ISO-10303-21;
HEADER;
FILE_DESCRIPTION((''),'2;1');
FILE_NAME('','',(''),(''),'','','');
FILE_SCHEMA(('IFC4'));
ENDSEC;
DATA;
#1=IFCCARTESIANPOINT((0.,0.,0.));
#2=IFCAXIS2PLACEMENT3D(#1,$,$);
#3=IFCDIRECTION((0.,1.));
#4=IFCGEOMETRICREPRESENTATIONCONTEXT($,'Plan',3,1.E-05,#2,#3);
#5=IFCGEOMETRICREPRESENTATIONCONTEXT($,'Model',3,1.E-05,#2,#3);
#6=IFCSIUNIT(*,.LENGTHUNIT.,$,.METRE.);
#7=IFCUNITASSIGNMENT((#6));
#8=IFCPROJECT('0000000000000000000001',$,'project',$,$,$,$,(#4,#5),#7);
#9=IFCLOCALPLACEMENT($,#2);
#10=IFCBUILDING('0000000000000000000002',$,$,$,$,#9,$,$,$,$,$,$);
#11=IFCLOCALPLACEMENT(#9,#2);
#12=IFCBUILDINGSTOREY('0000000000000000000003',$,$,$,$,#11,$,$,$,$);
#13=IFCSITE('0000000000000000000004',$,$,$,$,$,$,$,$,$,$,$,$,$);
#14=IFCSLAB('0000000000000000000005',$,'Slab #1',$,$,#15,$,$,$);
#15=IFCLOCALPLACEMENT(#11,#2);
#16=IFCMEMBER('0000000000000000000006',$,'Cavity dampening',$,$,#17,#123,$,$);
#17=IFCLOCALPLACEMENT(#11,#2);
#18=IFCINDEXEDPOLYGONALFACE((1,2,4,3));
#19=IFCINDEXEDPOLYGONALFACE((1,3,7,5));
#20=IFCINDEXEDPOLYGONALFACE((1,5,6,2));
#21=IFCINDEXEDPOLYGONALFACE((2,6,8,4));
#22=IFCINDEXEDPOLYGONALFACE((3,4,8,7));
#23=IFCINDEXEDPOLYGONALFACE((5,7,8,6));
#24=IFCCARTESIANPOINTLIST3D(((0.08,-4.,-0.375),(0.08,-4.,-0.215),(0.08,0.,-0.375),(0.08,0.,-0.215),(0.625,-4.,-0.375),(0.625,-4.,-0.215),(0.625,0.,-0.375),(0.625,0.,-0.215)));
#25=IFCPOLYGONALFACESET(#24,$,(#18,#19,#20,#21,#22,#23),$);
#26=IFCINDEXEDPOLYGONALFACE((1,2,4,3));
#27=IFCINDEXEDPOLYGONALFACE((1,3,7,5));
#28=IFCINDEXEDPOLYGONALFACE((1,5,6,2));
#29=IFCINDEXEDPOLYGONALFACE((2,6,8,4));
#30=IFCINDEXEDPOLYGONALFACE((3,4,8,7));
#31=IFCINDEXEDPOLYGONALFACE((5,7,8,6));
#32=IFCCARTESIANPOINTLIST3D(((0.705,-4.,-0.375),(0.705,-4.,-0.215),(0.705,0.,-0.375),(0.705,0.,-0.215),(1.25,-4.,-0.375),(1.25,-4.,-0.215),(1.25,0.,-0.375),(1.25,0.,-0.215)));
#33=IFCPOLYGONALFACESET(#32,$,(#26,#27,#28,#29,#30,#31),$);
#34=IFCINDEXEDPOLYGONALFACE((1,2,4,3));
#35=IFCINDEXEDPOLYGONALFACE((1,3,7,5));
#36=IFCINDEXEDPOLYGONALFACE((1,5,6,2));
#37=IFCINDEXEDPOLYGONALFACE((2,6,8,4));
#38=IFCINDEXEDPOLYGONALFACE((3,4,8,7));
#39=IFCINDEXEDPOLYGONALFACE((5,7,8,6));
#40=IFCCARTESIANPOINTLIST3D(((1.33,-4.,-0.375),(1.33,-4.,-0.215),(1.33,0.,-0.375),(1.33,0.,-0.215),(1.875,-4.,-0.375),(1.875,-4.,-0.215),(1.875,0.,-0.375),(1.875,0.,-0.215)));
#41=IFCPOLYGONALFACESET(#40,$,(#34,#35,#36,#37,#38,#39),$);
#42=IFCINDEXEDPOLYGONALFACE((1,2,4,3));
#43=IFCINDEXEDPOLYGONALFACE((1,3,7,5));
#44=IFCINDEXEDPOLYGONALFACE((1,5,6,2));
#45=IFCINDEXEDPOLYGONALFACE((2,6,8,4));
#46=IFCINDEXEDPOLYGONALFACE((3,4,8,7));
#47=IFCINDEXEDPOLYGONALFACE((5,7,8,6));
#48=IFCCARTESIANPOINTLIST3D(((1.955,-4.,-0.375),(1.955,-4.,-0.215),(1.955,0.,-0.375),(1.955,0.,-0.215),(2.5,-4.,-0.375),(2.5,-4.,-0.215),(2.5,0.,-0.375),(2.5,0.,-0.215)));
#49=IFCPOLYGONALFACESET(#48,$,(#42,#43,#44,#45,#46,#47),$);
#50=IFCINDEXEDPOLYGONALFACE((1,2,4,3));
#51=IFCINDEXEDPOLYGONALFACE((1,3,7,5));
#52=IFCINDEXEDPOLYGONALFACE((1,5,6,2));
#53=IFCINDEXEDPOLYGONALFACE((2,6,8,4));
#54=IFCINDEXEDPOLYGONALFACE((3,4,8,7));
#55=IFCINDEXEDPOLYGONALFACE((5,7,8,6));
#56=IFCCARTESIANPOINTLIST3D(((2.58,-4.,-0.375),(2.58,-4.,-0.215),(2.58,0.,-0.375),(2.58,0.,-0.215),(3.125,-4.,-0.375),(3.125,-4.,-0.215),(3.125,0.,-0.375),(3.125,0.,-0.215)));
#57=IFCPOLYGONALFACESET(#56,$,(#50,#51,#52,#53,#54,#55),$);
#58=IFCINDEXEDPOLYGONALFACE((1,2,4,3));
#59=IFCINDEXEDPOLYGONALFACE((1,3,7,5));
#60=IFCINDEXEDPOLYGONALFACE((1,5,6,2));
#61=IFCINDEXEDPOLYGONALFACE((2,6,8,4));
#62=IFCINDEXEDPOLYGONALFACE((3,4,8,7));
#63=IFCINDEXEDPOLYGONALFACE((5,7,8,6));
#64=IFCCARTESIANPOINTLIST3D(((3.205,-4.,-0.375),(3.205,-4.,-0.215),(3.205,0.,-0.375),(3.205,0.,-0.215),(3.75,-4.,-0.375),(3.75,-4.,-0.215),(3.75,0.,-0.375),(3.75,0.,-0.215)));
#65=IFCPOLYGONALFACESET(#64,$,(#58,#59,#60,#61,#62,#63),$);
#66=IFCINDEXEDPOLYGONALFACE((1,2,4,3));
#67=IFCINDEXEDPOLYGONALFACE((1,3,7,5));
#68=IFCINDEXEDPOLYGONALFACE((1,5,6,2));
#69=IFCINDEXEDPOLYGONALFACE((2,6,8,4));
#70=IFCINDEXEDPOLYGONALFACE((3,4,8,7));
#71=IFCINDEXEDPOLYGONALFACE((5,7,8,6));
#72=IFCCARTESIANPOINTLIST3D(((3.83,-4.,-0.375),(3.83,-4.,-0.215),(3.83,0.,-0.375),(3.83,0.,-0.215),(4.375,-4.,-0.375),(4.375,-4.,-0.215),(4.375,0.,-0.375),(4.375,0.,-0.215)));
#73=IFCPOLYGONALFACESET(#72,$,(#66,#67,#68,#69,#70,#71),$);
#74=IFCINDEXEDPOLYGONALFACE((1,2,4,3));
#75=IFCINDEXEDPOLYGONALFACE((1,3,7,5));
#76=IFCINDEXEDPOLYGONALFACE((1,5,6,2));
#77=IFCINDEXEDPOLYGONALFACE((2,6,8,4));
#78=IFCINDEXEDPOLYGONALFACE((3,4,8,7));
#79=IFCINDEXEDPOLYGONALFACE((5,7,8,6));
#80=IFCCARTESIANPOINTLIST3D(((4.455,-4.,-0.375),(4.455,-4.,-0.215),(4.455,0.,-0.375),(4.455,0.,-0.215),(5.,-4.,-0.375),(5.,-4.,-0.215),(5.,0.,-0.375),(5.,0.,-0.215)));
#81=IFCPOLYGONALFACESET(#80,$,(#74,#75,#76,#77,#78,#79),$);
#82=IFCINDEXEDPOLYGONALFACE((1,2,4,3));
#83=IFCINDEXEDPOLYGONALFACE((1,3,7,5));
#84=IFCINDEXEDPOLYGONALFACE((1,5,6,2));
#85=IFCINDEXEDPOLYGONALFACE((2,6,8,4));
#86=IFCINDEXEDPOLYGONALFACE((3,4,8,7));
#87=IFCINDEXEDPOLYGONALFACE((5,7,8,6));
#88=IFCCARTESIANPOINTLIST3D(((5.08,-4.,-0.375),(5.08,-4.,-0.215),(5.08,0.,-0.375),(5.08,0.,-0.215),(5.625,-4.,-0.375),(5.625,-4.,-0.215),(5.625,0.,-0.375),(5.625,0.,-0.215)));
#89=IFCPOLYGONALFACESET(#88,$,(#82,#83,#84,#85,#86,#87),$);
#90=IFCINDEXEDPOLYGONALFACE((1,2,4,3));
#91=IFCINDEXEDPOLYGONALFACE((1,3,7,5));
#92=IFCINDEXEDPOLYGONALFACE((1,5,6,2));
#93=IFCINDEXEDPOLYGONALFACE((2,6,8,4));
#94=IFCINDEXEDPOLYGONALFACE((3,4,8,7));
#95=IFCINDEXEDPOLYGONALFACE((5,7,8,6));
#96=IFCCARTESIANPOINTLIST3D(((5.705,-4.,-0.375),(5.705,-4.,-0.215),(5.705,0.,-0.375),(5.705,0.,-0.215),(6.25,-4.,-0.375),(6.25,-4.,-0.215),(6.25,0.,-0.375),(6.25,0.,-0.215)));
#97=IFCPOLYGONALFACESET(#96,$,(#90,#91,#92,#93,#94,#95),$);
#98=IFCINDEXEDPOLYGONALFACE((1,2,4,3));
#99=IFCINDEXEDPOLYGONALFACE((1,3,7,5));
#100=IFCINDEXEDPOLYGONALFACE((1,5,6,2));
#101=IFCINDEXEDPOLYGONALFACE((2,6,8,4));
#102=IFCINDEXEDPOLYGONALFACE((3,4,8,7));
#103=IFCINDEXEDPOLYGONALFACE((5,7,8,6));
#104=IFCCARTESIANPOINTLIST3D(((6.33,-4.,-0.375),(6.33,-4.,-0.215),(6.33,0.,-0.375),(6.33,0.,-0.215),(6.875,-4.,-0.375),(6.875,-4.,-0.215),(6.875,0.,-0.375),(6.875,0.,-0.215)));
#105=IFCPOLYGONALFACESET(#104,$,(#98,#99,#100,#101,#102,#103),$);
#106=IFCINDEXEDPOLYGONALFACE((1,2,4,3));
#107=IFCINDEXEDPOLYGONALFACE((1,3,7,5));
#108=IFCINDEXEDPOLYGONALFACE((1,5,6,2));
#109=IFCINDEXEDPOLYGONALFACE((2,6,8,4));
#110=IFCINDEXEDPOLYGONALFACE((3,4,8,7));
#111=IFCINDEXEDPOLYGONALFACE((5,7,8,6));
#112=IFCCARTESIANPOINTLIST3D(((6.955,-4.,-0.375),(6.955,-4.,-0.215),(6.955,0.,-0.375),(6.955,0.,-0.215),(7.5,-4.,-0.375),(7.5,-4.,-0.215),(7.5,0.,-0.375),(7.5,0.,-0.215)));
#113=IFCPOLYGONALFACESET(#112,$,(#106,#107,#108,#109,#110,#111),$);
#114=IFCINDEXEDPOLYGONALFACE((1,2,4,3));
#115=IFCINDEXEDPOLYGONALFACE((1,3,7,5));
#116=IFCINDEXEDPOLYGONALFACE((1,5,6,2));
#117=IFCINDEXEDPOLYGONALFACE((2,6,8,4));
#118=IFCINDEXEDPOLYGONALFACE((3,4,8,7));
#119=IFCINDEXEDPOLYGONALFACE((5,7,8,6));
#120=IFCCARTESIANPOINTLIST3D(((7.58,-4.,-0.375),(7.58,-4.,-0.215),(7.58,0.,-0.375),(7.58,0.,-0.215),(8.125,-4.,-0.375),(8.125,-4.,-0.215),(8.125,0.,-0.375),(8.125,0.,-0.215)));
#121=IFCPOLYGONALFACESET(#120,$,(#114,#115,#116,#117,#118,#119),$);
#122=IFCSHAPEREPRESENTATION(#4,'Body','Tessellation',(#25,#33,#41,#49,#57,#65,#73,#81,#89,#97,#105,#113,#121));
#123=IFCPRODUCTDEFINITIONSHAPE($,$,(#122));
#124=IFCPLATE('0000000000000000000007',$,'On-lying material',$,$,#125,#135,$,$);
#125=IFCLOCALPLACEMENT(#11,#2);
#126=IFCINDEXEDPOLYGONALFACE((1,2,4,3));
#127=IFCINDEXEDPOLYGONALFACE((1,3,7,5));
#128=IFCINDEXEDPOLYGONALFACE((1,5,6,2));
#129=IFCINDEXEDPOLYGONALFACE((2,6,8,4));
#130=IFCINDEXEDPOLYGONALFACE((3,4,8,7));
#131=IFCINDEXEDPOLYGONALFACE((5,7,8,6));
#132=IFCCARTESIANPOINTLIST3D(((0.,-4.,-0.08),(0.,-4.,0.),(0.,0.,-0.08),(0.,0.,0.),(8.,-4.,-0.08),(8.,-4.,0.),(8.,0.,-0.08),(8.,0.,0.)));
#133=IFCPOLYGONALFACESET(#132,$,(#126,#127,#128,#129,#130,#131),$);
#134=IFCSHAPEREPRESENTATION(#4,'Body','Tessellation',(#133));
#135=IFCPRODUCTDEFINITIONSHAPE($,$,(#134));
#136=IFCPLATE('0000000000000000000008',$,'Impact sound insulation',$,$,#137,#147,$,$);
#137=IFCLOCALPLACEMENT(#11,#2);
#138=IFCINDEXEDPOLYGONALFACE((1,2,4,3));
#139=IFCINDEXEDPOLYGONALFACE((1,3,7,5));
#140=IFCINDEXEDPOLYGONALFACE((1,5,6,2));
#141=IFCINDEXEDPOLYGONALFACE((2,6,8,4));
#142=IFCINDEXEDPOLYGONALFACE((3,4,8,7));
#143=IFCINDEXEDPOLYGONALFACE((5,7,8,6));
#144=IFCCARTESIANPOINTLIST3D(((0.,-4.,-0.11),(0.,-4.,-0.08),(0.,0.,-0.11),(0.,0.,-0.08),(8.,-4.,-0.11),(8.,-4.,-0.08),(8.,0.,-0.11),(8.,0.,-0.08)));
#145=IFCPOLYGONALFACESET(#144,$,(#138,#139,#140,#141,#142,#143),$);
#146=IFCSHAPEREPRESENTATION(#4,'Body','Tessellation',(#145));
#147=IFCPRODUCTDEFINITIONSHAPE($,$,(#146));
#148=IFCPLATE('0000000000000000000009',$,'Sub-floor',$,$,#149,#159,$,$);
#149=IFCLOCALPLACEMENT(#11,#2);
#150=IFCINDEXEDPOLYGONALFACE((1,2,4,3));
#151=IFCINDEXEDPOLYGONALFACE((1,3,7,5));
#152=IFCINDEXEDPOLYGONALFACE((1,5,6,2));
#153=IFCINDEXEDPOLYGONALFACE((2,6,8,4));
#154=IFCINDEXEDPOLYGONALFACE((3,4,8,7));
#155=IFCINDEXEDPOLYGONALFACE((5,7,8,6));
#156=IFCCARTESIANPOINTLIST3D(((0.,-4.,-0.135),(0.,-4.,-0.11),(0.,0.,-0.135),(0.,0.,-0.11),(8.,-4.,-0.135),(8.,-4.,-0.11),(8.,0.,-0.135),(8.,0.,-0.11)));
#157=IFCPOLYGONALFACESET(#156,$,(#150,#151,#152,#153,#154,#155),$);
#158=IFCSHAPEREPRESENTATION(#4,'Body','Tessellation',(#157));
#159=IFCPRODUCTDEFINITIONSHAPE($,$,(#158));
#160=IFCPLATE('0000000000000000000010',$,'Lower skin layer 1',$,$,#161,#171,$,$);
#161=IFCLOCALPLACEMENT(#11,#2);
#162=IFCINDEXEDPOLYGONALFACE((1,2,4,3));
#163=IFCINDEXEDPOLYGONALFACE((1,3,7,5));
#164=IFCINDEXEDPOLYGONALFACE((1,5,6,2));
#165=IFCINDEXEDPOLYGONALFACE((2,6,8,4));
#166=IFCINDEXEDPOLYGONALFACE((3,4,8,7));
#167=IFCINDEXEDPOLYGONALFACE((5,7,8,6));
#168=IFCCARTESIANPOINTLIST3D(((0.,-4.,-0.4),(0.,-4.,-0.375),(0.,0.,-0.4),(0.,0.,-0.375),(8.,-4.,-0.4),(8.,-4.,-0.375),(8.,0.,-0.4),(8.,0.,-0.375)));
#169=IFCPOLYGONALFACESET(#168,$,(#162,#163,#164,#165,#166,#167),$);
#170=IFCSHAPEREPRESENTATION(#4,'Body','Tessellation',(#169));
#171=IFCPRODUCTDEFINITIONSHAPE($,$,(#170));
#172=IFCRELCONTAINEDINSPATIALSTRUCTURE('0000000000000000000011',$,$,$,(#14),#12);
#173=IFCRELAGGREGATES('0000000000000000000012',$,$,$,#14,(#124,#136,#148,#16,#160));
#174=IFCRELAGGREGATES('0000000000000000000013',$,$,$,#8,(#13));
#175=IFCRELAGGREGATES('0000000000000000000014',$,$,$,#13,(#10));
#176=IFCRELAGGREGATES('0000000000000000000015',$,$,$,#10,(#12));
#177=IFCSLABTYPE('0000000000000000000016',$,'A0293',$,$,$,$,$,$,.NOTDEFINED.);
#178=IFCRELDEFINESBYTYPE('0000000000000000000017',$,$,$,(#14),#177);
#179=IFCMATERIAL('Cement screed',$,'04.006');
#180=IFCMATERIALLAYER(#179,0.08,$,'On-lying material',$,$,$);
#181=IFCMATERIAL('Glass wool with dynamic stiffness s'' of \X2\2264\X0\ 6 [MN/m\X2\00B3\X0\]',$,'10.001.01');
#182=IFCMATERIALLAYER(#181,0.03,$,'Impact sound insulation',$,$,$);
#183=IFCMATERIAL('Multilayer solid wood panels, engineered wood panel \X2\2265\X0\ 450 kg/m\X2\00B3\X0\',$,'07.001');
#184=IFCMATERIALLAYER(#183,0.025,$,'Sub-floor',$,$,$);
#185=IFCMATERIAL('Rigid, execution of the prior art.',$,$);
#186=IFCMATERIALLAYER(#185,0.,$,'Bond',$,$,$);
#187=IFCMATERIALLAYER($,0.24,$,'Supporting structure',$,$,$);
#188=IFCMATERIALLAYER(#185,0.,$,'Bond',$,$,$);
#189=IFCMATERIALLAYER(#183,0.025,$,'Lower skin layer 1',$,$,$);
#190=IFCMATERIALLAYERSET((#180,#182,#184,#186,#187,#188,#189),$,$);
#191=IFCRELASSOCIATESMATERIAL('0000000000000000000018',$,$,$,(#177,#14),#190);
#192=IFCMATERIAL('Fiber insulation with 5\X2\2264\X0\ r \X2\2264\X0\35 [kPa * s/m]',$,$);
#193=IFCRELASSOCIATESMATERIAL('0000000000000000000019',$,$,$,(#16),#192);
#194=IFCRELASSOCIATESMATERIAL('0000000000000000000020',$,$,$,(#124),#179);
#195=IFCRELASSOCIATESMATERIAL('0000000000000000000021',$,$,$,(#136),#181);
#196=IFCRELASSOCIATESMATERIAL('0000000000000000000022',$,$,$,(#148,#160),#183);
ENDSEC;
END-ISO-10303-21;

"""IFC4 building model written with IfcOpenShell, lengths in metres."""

from ifc_helpers import new_model, si_unit, direction, frame, frame_2d, origin, origin_with_axes, place, context, project, spatial, rectangle, extrude, material, layer, layer_set, type_object, element, aggregate, save


model = new_model("IFC4")

# Units and contexts
plan_context = context("Plan", 3, precision=1e-05, world=origin(), true_north=direction((0.0, 1.0)))
model_context = context("Model", 3, precision=1e-05, world=origin(), true_north=direction((0.0, 1.0)))
ifc_project = project(units=[si_unit("LENGTHUNIT", "METRE")], contexts=[plan_context, model_context])

# Site, building, storey
site = spatial("IfcSite", under=ifc_project)
building_placement = place(None, origin())
building = spatial("IfcBuilding", under=site, at=building_placement)
storey_placement = place(building_placement, origin())
storey = spatial("IfcBuildingStorey", under=building, at=storey_placement)

# Slab, member, plates
ifc_material_1 = material(Name="Cement screed", Category="04.006")
ifc_layer_1 = layer(ifc_material_1, 0.08, Name="On-lying material")
ifc_material_2 = material(Name="Glass wool with dynamic stiffness s' of ≤ 6 [MN/m³]", Category="10.001.01")
ifc_layer_2 = layer(ifc_material_2, 0.03, Name="Impact sound insulation")
ifc_material_3 = material(Name="Multilayer solid wood panels, engineered wood panel ≥ 450 kg/m³", Category="07.001")
ifc_layer_3 = layer(ifc_material_3, 0.025, Name="Sub-floor")
ifc_material_4 = material(Name="Rigid, execution of the prior art.")
ifc_layer_4 = layer(ifc_material_4, 0.0, Name="Bond")
ifc_layer_5 = layer(None, 0.24, Name="Supporting structure")
ifc_layer_6 = layer(ifc_material_4, 0.0, Name="Bond")
ifc_layer_7 = layer(ifc_material_3, 0.025, Name="Lower skin layer 1")
ifc_layer_set = layer_set([ifc_layer_1, ifc_layer_2, ifc_layer_3, ifc_layer_4, ifc_layer_5, ifc_layer_6, ifc_layer_7])
slab_type = type_object("IfcSlabType", Name="A0293", PredefinedType="NOTDEFINED", material=ifc_layer_set)
slab_placement = place(None, frame((0.0, 0.0, 0.0), z_axis=(0.0, 0.0, -1.0), x_axis=(1.0, 0.0, 0.0)))
slab = element("IfcSlab", 1, at=slab_placement, inside=storey, type_object=slab_type, material=ifc_layer_set, Name="Slab #1")
ifc_material_5 = material(Name="Fiber insulation with 5≤ r ≤35 [kPa * s/m]")
member_1_placement = place(slab_placement, origin())
member_1 = element("IfcMember", 2, at=member_1_placement, material=ifc_material_5, Name="Cavity dampening", context=plan_context, shape_type="SweptSolid", body=[
    extrude(rectangle(XDim=0.545, YDim=0.16, at=frame_2d((0.2725, 0.08), x_axis=(1.0, 0.0))), frame((0.08, 4.0, 0.215), z_axis=(0.0, -1.0, 0.0), x_axis=(1.0, 0.0, 0.0)), (0.0, 0.0, 1.0), 4.0),
    extrude(rectangle(XDim=0.545, YDim=0.16, at=frame_2d((0.2725, 0.08), x_axis=(1.0, 0.0))), frame((0.705, 4.0, 0.215), z_axis=(0.0, -1.0, 0.0), x_axis=(1.0, 0.0, 0.0)), (0.0, 0.0, 1.0), 4.0),
    extrude(rectangle(XDim=0.545, YDim=0.16, at=frame_2d((0.2725, 0.08), x_axis=(1.0, 0.0))), frame((1.33, 4.0, 0.215), z_axis=(0.0, -1.0, 0.0), x_axis=(1.0, 0.0, 0.0)), (0.0, 0.0, 1.0), 4.0),
    extrude(rectangle(XDim=0.545, YDim=0.16, at=frame_2d((0.2725, 0.08), x_axis=(1.0, 0.0))), frame((1.955, 4.0, 0.215), z_axis=(0.0, -1.0, 0.0), x_axis=(1.0, 0.0, 0.0)), (0.0, 0.0, 1.0), 4.0),
    extrude(rectangle(XDim=0.545, YDim=0.16, at=frame_2d((0.2725, 0.08), x_axis=(1.0, 0.0))), frame((2.58, 4.0, 0.215), z_axis=(0.0, -1.0, 0.0), x_axis=(1.0, 0.0, 0.0)), (0.0, 0.0, 1.0), 4.0),
    extrude(rectangle(XDim=0.545, YDim=0.16, at=frame_2d((0.2725, 0.08), x_axis=(1.0, 0.0))), frame((3.205, 4.0, 0.215), z_axis=(0.0, -1.0, 0.0), x_axis=(1.0, 0.0, 0.0)), (0.0, 0.0, 1.0), 4.0),
    extrude(rectangle(XDim=0.545, YDim=0.16, at=frame_2d((0.2725, 0.08), x_axis=(1.0, 0.0))), frame((3.83, 4.0, 0.215), z_axis=(0.0, -1.0, 0.0), x_axis=(1.0, 0.0, 0.0)), (0.0, 0.0, 1.0), 4.0),
    extrude(rectangle(XDim=0.545, YDim=0.16, at=frame_2d((0.2725, 0.08), x_axis=(1.0, 0.0))), frame((4.455, 4.0, 0.215), z_axis=(0.0, -1.0, 0.0), x_axis=(1.0, 0.0, 0.0)), (0.0, 0.0, 1.0), 4.0),
    extrude(rectangle(XDim=0.545, YDim=0.16, at=frame_2d((0.2725, 0.08), x_axis=(1.0, 0.0))), frame((5.08, 4.0, 0.215), z_axis=(0.0, -1.0, 0.0), x_axis=(1.0, 0.0, 0.0)), (0.0, 0.0, 1.0), 4.0),
    extrude(rectangle(XDim=0.545, YDim=0.16, at=frame_2d((0.2725, 0.08), x_axis=(1.0, 0.0))), frame((5.705, 4.0, 0.215), z_axis=(0.0, -1.0, 0.0), x_axis=(1.0, 0.0, 0.0)), (0.0, 0.0, 1.0), 4.0),
    extrude(rectangle(XDim=0.545, YDim=0.16, at=frame_2d((0.2725, 0.08), x_axis=(1.0, 0.0))), frame((6.33, 4.0, 0.215), z_axis=(0.0, -1.0, 0.0), x_axis=(1.0, 0.0, 0.0)), (0.0, 0.0, 1.0), 4.0),
    extrude(rectangle(XDim=0.545, YDim=0.16, at=frame_2d((0.2725, 0.08), x_axis=(1.0, 0.0))), frame((6.955, 4.0, 0.215), z_axis=(0.0, -1.0, 0.0), x_axis=(1.0, 0.0, 0.0)), (0.0, 0.0, 1.0), 4.0),
    extrude(rectangle(XDim=0.545, YDim=0.16, at=frame_2d((0.2725, 0.08), x_axis=(1.0, 0.0))), frame((7.58, 4.0, 0.215), z_axis=(0.0, -1.0, 0.0), x_axis=(1.0, 0.0, 0.0)), (0.0, 0.0, 1.0), 4.0),
])
plate_1_placement = place(slab_placement, origin())
plate_1 = element("IfcPlate", 3, at=plate_1_placement, material=ifc_material_1, Name="On-lying material", context=plan_context, shape_type="SweptSolid", body=[
    extrude(rectangle(XDim=8.0, YDim=4.0, at=frame_2d((4.0, 2.0), x_axis=(1.0, 0.0))), origin_with_axes(), (0.0, 0.0, 1.0), 0.08),
])
plate_2_placement = place(slab_placement, origin())
plate_2 = element("IfcPlate", 4, at=plate_2_placement, material=ifc_material_2, Name="Impact sound insulation", context=plan_context, shape_type="SweptSolid", body=[
    extrude(rectangle(XDim=8.0, YDim=4.0, at=frame_2d((4.0, 2.0), x_axis=(1.0, 0.0))), frame((0.0, 0.0, 0.08), z_axis=(0.0, 0.0, 1.0), x_axis=(1.0, 0.0, 0.0)), (0.0, 0.0, 1.0), 0.03),
])
plate_3_placement = place(slab_placement, origin())
plate_3 = element("IfcPlate", 5, at=plate_3_placement, material=ifc_material_3, Name="Sub-floor", context=plan_context, shape_type="SweptSolid", body=[
    extrude(rectangle(XDim=8.0, YDim=4.0, at=frame_2d((4.0, 2.0), x_axis=(1.0, 0.0))), frame((0.0, 0.0, 0.11), z_axis=(0.0, 0.0, 1.0), x_axis=(1.0, 0.0, 0.0)), (0.0, 0.0, 1.0), 0.025),
])
plate_4_placement = place(slab_placement, origin())
plate_4 = element("IfcPlate", 6, at=plate_4_placement, material=ifc_material_3, Name="Lower skin layer 1", context=plan_context, shape_type="SweptSolid", body=[
    extrude(rectangle(XDim=8.0, YDim=4.0, at=frame_2d((4.0, 2.0), x_axis=(1.0, 0.0))), frame((0.0, 0.0, 0.375), z_axis=(0.0, 0.0, 1.0), x_axis=(1.0, 0.0, 0.0)), (0.0, 0.0, 1.0), 0.025),
])
aggregate(slab, [plate_1, plate_2, plate_3, member_1, plate_4])

save(model, "model.ifc")
